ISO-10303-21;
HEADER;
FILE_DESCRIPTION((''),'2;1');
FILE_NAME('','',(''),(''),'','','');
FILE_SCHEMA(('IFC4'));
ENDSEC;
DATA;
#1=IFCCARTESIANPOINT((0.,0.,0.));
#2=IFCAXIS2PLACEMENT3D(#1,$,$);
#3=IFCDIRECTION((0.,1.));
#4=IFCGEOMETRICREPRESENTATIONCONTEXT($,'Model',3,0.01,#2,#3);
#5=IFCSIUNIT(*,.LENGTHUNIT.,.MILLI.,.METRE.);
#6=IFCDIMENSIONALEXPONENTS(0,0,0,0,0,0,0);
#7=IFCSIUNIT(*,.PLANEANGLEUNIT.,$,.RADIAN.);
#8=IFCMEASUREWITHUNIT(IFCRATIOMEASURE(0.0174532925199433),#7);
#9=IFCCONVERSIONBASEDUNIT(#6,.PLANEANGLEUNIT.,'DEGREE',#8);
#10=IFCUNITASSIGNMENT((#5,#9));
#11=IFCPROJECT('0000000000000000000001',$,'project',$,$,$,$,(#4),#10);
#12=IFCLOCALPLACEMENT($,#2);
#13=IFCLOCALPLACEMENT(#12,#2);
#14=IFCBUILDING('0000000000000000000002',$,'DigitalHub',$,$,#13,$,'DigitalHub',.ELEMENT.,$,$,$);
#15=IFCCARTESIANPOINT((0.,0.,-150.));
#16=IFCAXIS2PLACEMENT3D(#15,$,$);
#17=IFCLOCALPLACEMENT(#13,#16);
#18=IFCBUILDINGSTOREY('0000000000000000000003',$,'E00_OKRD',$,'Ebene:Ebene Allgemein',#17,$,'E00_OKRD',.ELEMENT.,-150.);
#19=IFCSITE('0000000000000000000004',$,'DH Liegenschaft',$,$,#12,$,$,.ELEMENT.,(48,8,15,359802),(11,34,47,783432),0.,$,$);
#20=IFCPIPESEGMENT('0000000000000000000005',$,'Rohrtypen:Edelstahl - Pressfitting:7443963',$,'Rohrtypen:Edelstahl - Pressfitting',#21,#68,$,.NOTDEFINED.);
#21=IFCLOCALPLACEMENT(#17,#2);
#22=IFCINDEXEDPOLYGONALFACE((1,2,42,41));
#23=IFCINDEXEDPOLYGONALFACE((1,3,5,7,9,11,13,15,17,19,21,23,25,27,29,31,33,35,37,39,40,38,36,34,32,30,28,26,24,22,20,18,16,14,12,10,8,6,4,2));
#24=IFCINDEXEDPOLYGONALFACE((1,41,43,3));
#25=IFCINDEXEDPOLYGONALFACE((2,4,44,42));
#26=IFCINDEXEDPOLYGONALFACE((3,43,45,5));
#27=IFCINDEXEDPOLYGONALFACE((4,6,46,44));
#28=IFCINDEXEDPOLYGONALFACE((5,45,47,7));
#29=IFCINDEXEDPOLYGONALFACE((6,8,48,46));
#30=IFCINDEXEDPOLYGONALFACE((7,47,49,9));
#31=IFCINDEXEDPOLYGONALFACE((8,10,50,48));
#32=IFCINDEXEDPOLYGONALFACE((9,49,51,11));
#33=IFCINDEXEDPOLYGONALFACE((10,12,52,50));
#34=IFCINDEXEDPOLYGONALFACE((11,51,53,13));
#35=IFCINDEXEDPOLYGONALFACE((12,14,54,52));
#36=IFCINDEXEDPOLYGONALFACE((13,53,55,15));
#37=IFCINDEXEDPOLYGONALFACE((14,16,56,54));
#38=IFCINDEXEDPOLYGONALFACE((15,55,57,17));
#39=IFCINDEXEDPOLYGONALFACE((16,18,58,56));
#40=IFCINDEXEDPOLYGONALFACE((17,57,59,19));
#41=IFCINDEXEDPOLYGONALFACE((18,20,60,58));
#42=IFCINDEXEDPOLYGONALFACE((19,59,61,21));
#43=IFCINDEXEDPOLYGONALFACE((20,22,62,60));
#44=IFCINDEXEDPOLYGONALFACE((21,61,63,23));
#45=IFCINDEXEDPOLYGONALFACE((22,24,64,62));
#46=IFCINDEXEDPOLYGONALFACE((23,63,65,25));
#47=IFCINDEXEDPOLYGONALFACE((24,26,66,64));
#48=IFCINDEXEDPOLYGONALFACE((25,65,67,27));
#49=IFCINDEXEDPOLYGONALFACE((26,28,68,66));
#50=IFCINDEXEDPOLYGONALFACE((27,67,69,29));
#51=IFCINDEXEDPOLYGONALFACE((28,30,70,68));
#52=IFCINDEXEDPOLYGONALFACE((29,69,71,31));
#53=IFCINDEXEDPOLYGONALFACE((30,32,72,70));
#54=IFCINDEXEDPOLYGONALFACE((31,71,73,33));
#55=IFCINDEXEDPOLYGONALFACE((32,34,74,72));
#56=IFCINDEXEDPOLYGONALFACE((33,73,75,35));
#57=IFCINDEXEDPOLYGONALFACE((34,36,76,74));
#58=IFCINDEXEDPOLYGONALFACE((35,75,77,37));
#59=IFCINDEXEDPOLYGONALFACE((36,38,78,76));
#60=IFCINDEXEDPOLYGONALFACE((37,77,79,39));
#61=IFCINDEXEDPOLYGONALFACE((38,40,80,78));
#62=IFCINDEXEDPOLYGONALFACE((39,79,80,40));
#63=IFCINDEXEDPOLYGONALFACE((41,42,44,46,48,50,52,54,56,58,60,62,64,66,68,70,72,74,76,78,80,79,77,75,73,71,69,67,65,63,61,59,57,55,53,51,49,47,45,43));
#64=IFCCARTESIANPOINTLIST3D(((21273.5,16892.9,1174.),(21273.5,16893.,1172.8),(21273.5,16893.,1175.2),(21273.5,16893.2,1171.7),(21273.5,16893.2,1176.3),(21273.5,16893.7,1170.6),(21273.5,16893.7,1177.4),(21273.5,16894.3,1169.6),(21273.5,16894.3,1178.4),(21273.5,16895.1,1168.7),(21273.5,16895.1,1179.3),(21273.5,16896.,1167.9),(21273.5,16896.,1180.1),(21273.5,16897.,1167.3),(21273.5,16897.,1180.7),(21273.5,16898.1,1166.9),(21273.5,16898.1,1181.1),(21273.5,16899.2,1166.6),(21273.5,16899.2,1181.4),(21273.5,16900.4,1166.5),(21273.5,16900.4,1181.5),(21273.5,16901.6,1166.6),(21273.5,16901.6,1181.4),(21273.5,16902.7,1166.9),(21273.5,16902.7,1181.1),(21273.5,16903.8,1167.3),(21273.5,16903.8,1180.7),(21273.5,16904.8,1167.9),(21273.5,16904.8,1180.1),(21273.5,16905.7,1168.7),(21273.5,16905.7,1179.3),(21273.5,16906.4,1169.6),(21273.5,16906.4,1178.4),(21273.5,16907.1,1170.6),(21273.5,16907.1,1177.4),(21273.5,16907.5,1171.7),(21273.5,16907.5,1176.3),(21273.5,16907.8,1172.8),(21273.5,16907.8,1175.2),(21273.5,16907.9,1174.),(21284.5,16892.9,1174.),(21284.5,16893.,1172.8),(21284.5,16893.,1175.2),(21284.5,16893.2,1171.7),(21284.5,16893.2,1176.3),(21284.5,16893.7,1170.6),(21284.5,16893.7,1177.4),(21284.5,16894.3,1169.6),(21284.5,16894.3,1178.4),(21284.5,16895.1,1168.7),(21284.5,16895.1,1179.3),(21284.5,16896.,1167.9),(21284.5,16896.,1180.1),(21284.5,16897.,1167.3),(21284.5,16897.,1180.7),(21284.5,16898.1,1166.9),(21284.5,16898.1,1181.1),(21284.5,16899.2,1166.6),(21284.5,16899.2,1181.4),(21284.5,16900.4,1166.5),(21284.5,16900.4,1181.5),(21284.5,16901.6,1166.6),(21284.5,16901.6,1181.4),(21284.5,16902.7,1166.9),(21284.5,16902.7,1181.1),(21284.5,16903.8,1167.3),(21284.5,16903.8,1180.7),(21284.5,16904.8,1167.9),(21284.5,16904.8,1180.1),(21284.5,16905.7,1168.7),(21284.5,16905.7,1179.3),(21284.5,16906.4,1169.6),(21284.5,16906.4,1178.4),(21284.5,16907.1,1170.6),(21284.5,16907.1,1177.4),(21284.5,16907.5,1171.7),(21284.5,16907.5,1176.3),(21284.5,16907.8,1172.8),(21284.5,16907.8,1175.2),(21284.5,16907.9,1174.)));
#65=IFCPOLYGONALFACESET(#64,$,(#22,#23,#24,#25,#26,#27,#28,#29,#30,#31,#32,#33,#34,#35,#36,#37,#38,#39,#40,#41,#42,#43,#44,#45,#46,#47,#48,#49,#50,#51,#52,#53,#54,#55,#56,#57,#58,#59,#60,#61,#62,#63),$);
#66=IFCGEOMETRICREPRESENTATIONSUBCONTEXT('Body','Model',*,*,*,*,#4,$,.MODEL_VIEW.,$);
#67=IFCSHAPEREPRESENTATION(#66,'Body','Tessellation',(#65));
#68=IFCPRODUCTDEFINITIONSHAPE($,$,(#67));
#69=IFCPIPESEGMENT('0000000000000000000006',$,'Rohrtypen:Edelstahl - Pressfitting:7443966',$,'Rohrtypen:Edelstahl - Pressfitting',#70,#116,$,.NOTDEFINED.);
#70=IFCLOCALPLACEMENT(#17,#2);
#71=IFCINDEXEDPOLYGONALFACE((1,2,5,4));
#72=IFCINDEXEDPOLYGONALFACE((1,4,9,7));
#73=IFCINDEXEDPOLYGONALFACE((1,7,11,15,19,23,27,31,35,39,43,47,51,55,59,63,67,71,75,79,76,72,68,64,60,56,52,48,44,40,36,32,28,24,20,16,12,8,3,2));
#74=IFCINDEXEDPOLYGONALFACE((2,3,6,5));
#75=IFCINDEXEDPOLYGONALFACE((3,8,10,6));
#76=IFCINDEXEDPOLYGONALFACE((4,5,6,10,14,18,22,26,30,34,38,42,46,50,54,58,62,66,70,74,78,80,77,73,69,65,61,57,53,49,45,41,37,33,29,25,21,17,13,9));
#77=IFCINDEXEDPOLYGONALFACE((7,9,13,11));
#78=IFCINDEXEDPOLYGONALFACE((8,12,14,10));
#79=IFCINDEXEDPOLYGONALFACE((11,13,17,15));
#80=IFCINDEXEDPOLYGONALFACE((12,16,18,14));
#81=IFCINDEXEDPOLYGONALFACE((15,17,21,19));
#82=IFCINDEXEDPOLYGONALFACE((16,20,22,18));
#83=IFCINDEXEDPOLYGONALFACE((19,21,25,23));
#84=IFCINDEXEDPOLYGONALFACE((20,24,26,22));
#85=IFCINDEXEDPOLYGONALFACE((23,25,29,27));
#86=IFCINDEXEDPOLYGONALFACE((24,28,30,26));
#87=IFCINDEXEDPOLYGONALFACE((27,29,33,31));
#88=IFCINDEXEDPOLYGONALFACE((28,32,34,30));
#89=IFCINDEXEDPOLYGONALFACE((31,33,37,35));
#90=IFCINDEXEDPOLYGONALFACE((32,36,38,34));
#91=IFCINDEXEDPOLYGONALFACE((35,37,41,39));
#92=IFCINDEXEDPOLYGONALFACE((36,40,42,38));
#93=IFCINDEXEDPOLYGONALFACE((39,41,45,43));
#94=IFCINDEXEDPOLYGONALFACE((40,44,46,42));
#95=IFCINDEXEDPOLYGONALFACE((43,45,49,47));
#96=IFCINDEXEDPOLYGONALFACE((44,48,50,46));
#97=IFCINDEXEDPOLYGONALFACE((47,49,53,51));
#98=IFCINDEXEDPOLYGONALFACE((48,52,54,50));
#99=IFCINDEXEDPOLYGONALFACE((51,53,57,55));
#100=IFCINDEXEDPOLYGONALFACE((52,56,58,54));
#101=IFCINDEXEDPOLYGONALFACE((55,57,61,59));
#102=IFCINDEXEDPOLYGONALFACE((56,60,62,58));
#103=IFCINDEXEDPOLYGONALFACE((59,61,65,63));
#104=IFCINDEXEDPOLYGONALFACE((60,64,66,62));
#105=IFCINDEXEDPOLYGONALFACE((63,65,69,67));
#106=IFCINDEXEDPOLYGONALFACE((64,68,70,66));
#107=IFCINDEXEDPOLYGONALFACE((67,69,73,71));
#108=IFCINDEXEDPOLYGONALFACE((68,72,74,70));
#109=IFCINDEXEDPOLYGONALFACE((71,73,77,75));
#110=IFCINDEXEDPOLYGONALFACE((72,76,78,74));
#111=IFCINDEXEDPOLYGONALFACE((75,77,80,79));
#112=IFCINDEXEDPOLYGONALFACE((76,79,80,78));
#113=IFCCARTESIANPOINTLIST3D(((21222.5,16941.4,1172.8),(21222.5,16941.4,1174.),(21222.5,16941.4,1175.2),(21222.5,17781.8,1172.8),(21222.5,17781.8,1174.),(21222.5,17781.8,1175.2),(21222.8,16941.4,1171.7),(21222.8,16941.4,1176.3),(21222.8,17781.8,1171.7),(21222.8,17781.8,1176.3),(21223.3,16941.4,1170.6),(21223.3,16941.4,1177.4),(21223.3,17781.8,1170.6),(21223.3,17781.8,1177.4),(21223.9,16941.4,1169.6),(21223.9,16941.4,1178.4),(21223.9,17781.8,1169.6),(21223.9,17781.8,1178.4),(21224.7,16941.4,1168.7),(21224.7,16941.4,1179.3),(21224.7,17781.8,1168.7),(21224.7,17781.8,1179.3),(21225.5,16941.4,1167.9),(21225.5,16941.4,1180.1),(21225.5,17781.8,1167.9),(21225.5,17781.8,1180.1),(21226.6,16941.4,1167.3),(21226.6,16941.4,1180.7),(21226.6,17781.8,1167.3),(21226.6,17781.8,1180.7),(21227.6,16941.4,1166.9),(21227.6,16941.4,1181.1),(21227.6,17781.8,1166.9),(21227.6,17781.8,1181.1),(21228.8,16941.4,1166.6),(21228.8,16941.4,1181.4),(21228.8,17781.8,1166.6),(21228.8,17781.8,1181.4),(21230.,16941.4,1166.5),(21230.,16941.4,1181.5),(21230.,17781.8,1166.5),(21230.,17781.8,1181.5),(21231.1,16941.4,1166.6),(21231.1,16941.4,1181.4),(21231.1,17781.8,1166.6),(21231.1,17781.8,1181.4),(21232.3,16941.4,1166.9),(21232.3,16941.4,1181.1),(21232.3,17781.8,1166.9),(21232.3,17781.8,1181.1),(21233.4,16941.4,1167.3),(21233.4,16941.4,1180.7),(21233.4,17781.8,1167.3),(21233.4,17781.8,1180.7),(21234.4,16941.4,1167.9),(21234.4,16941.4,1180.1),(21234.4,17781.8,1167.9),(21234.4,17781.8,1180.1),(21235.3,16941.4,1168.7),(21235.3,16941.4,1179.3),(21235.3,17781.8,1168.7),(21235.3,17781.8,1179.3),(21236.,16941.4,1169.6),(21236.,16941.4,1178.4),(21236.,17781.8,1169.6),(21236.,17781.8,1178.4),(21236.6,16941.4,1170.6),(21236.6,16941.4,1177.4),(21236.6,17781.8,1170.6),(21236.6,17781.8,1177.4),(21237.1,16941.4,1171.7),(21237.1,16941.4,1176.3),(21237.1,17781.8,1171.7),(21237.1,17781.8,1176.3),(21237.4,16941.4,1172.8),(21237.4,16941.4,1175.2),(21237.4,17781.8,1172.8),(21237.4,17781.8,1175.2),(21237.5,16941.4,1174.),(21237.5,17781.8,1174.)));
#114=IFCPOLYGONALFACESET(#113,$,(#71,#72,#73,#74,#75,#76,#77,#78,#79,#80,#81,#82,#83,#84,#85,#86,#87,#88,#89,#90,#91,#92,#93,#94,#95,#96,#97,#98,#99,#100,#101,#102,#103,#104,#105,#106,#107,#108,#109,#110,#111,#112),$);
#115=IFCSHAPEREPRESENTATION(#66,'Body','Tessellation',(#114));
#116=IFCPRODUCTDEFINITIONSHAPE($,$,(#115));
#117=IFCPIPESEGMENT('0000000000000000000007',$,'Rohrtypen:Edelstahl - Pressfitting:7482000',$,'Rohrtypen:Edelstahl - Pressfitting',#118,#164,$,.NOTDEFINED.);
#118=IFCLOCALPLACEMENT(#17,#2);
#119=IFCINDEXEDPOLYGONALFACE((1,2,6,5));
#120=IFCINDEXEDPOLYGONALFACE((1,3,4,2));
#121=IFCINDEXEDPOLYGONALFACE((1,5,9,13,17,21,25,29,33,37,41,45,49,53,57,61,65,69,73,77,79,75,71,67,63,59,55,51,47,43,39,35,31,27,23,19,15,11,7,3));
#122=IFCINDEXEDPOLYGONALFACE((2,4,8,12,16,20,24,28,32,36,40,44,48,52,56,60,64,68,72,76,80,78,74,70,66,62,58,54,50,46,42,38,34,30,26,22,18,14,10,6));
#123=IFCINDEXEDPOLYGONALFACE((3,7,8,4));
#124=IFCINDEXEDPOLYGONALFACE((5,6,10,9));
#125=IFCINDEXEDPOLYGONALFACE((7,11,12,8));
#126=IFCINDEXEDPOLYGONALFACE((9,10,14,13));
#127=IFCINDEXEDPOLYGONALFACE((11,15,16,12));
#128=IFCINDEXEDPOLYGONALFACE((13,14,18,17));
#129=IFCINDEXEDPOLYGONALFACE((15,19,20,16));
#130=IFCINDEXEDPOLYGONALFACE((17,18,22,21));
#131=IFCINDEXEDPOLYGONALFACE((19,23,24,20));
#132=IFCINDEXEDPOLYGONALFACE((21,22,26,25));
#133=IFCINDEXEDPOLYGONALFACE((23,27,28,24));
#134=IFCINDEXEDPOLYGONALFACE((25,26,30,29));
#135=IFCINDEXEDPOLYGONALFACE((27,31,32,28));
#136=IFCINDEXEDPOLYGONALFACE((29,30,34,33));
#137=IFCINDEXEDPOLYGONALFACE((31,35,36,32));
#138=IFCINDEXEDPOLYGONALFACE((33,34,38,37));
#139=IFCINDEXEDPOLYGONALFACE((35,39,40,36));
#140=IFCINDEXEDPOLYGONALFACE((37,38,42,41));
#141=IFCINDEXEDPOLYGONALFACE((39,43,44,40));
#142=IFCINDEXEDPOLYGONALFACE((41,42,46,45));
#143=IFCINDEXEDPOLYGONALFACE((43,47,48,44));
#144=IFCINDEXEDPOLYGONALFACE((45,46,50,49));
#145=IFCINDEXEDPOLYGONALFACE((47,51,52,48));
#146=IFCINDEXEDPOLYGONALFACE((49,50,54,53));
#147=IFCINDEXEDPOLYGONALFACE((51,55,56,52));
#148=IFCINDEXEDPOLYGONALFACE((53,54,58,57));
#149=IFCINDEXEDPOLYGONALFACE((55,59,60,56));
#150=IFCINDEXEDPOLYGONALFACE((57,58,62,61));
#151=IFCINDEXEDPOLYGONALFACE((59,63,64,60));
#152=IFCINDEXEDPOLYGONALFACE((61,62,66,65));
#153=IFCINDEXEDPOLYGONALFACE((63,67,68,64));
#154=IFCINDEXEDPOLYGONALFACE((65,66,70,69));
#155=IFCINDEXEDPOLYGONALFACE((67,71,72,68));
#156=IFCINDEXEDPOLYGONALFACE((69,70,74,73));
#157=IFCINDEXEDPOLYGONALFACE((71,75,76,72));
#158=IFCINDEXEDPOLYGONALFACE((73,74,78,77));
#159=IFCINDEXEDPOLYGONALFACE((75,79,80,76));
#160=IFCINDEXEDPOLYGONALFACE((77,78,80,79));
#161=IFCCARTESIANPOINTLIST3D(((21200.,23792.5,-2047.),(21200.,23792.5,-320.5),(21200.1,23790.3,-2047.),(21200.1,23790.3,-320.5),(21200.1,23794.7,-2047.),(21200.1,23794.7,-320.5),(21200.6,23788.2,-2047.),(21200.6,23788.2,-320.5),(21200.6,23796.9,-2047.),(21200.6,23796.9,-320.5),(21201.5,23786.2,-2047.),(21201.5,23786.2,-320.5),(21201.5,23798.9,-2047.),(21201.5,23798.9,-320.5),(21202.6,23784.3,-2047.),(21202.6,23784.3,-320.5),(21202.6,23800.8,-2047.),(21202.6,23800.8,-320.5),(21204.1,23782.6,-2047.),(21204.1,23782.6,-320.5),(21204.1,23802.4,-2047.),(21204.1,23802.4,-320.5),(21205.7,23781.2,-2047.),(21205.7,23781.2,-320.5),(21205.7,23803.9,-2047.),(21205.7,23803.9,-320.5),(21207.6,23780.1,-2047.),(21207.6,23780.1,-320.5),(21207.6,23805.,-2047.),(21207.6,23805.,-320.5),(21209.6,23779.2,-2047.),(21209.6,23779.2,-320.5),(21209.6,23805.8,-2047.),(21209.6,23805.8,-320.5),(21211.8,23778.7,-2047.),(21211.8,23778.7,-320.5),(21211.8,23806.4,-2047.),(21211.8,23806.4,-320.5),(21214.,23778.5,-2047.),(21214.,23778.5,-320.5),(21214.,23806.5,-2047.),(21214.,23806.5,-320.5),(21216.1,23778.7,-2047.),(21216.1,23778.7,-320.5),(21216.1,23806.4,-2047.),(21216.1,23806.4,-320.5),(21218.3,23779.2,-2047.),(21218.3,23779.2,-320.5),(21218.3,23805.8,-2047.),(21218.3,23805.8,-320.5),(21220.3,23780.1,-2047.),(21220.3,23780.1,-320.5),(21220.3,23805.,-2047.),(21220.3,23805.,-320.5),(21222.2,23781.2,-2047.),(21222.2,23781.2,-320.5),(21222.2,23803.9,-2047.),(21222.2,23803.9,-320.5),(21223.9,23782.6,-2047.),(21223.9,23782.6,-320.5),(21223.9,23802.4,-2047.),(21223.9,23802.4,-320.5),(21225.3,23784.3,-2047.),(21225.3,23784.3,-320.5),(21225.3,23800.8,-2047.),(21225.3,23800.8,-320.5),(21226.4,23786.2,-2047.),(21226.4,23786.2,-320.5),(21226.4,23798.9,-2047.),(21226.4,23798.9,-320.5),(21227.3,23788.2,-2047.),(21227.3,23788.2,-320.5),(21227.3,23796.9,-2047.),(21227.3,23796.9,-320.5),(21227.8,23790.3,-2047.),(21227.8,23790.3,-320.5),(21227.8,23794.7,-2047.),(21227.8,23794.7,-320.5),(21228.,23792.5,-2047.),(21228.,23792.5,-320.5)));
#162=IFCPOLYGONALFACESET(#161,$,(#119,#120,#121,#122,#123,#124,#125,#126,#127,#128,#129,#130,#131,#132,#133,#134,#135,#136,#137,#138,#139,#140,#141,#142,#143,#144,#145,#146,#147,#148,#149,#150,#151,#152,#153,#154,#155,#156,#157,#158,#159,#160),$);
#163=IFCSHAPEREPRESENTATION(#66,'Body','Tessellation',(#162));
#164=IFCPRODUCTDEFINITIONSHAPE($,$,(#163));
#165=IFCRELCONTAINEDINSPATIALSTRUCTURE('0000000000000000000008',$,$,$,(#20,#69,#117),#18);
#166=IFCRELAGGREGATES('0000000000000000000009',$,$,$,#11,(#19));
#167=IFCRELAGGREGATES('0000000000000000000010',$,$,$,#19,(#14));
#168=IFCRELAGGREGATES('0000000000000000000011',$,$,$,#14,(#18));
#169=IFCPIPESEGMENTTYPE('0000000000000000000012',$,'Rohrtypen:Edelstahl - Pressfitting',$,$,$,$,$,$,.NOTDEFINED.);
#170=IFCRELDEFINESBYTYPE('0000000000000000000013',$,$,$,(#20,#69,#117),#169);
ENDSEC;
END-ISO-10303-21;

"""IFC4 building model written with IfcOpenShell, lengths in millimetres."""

from ifc_helpers import new_model, entity, si_unit, converted_unit, direction, frame, origin, place, context, subcontext, project, spatial, indexed_curve, outline, extrude, type_object, element, save


model = new_model("IFC4")

# Units and contexts
model_context = context("Model", 3, precision=0.01, world=origin(), true_north=direction((0.0, 1.0)))
body_context = subcontext(model_context, "Body", "Model", "MODEL_VIEW")
ifc_project = project(units=[si_unit("LENGTHUNIT", "METRE", prefix="MILLI"), converted_unit("PLANEANGLEUNIT", "DEGREE", entity("IfcRatioMeasure", 0.0174532925199433), si_unit("PLANEANGLEUNIT", "RADIAN"), dimensions=[0, 0, 0, 0, 0, 0, 0])], contexts=[model_context])

# Site, building, storey
site_placement = place(None, origin())
site = spatial("IfcSite", under=ifc_project, at=site_placement, Name="DH Liegenschaft", CompositionType="ELEMENT", RefLatitude=(48, 8, 15, 359802), RefLongitude=(11, 34, 47, 783432), RefElevation=0.0)
building_placement = place(site_placement, origin())
building = spatial("IfcBuilding", under=site, at=building_placement, Name="DigitalHub", LongName="DigitalHub", CompositionType="ELEMENT")
storey_placement = place(building_placement, frame((0.0, 0.0, -150.0)))
storey = spatial("IfcBuildingStorey", under=building, at=storey_placement, Name="E00_OKRD", ObjectType="Ebene:Ebene Allgemein", LongName="E00_OKRD", CompositionType="ELEMENT", Elevation=-150.0)

# Pipe segments
pipe_segment_type_1 = type_object("IfcPipeSegmentType", Name="Rohrtypen:Edelstahl - Pressfitting", PredefinedType="NOTDEFINED")
pipe_segment_1_placement = place(storey_placement, frame((21273.5, 16891.3, 1164.9)))
element("IfcPipeSegment", 1, at=pipe_segment_1_placement, inside=storey, type_object=pipe_segment_type_1, Name="Rohrtypen:Edelstahl - Pressfitting:7443963", ObjectType="Rohrtypen:Edelstahl - Pressfitting", PredefinedType="NOTDEFINED", context=body_context, shape_type="SweptSolid", body=[
    extrude(outline(indexed_curve([(7.5, 0.0), (7.4, 1.2), (7.1, 2.3), (6.7, 3.4), (6.1, 4.4), (5.3, 5.3), (4.4, 6.1), (3.4, 6.7), (2.3, 7.1), (1.2, 7.4), (0.0, 7.5), (-1.2, 7.4), (-2.3, 7.1), (-3.4, 6.7), (-4.4, 6.1), (-5.3, 5.3), (-6.1, 4.4), (-6.7, 3.4), (-7.1, 2.3), (-7.4, 1.2), (-7.5, 0.0), (-7.4, -1.2), (-7.1, -2.3), (-6.7, -3.4), (-6.1, -4.4), (-5.3, -5.3), (-4.4, -6.1), (-3.4, -6.7), (-2.3, -7.1), (-1.2, -7.4), (0.0, -7.5), (1.2, -7.4), (2.3, -7.1), (3.4, -6.7), (4.4, -6.1), (5.3, -5.3), (6.1, -4.4), (6.7, -3.4), (7.1, -2.3), (7.4, -1.2), (7.5, 0.0)], self_intersect=False)), frame((0.0, 9.1, 9.1), z_axis=(1.0, 0.0, 0.0), x_axis=(0.0, -1.0, 0.0)), (0.0, 0.0, 1.0), 11.1),
])
pipe_segment_2_placement = place(storey_placement, frame((21220.9, 16941.4, 1164.9)))
element("IfcPipeSegment", 2, at=pipe_segment_2_placement, inside=storey, type_object=pipe_segment_type_1, Name="Rohrtypen:Edelstahl - Pressfitting:7443966", ObjectType="Rohrtypen:Edelstahl - Pressfitting", PredefinedType="NOTDEFINED", context=body_context, shape_type="SweptSolid", body=[
    extrude(outline(indexed_curve([(7.5, 0.0), (7.4, 1.2), (7.1, 2.3), (6.7, 3.4), (6.1, 4.4), (5.3, 5.3), (4.4, 6.1), (3.4, 6.7), (2.3, 7.1), (1.2, 7.4), (0.0, 7.5), (-1.2, 7.4), (-2.3, 7.1), (-3.4, 6.7), (-4.4, 6.1), (-5.3, 5.3), (-6.1, 4.4), (-6.7, 3.4), (-7.1, 2.3), (-7.4, 1.2), (-7.5, 0.0), (-7.4, -1.2), (-7.1, -2.3), (-6.7, -3.4), (-6.1, -4.4), (-5.3, -5.3), (-4.4, -6.1), (-3.4, -6.7), (-2.3, -7.1), (-1.2, -7.4), (0.0, -7.5), (1.2, -7.4), (2.3, -7.1), (3.4, -6.7), (4.4, -6.1), (5.3, -5.3), (6.1, -4.4), (6.7, -3.4), (7.1, -2.3), (7.4, -1.2), (7.5, 0.0)], self_intersect=False)), frame((9.1, 0.0, 9.1), z_axis=(0.0, 1.0, 0.000004), x_axis=(-1.0, 0.0, 0.0)), (0.0, 0.0, 1.0), 840.4),
])
pipe_segment_3_placement = place(storey_placement, frame((21198.4, 23776.9, -2047.0)))
element("IfcPipeSegment", 3, at=pipe_segment_3_placement, inside=storey, type_object=pipe_segment_type_1, Name="Rohrtypen:Edelstahl - Pressfitting:7482000", ObjectType="Rohrtypen:Edelstahl - Pressfitting", PredefinedType="NOTDEFINED", context=body_context, shape_type="SweptSolid", body=[
    extrude(outline(indexed_curve([(14.0, 0.0), (13.8, 2.2), (13.3, 4.3), (12.5, 6.4), (11.3, 8.2), (9.9, 9.9), (8.2, 11.3), (6.4, 12.5), (4.3, 13.3), (2.2, 13.8), (0.0, 14.0), (-2.2, 13.8), (-4.3, 13.3), (-6.4, 12.5), (-8.2, 11.3), (-9.9, 9.9), (-11.3, 8.2), (-12.5, 6.4), (-13.3, 4.3), (-13.8, 2.2), (-14.0, 0.0), (-13.8, -2.2), (-13.3, -4.3), (-12.5, -6.4), (-11.3, -8.2), (-9.9, -9.9), (-8.2, -11.3), (-6.4, -12.5), (-4.3, -13.3), (-2.2, -13.8), (0.0, -14.0), (2.2, -13.8), (4.3, -13.3), (6.4, -12.5), (8.2, -11.3), (9.9, -9.9), (11.3, -8.2), (12.5, -6.4), (13.3, -4.3), (13.8, -2.2), (14.0, 0.0)], self_intersect=False)), frame((15.6, 15.6, 0.0)), (0.0, 0.0, 1.0), 1726.5),
])

save(model, "model.ifc")
